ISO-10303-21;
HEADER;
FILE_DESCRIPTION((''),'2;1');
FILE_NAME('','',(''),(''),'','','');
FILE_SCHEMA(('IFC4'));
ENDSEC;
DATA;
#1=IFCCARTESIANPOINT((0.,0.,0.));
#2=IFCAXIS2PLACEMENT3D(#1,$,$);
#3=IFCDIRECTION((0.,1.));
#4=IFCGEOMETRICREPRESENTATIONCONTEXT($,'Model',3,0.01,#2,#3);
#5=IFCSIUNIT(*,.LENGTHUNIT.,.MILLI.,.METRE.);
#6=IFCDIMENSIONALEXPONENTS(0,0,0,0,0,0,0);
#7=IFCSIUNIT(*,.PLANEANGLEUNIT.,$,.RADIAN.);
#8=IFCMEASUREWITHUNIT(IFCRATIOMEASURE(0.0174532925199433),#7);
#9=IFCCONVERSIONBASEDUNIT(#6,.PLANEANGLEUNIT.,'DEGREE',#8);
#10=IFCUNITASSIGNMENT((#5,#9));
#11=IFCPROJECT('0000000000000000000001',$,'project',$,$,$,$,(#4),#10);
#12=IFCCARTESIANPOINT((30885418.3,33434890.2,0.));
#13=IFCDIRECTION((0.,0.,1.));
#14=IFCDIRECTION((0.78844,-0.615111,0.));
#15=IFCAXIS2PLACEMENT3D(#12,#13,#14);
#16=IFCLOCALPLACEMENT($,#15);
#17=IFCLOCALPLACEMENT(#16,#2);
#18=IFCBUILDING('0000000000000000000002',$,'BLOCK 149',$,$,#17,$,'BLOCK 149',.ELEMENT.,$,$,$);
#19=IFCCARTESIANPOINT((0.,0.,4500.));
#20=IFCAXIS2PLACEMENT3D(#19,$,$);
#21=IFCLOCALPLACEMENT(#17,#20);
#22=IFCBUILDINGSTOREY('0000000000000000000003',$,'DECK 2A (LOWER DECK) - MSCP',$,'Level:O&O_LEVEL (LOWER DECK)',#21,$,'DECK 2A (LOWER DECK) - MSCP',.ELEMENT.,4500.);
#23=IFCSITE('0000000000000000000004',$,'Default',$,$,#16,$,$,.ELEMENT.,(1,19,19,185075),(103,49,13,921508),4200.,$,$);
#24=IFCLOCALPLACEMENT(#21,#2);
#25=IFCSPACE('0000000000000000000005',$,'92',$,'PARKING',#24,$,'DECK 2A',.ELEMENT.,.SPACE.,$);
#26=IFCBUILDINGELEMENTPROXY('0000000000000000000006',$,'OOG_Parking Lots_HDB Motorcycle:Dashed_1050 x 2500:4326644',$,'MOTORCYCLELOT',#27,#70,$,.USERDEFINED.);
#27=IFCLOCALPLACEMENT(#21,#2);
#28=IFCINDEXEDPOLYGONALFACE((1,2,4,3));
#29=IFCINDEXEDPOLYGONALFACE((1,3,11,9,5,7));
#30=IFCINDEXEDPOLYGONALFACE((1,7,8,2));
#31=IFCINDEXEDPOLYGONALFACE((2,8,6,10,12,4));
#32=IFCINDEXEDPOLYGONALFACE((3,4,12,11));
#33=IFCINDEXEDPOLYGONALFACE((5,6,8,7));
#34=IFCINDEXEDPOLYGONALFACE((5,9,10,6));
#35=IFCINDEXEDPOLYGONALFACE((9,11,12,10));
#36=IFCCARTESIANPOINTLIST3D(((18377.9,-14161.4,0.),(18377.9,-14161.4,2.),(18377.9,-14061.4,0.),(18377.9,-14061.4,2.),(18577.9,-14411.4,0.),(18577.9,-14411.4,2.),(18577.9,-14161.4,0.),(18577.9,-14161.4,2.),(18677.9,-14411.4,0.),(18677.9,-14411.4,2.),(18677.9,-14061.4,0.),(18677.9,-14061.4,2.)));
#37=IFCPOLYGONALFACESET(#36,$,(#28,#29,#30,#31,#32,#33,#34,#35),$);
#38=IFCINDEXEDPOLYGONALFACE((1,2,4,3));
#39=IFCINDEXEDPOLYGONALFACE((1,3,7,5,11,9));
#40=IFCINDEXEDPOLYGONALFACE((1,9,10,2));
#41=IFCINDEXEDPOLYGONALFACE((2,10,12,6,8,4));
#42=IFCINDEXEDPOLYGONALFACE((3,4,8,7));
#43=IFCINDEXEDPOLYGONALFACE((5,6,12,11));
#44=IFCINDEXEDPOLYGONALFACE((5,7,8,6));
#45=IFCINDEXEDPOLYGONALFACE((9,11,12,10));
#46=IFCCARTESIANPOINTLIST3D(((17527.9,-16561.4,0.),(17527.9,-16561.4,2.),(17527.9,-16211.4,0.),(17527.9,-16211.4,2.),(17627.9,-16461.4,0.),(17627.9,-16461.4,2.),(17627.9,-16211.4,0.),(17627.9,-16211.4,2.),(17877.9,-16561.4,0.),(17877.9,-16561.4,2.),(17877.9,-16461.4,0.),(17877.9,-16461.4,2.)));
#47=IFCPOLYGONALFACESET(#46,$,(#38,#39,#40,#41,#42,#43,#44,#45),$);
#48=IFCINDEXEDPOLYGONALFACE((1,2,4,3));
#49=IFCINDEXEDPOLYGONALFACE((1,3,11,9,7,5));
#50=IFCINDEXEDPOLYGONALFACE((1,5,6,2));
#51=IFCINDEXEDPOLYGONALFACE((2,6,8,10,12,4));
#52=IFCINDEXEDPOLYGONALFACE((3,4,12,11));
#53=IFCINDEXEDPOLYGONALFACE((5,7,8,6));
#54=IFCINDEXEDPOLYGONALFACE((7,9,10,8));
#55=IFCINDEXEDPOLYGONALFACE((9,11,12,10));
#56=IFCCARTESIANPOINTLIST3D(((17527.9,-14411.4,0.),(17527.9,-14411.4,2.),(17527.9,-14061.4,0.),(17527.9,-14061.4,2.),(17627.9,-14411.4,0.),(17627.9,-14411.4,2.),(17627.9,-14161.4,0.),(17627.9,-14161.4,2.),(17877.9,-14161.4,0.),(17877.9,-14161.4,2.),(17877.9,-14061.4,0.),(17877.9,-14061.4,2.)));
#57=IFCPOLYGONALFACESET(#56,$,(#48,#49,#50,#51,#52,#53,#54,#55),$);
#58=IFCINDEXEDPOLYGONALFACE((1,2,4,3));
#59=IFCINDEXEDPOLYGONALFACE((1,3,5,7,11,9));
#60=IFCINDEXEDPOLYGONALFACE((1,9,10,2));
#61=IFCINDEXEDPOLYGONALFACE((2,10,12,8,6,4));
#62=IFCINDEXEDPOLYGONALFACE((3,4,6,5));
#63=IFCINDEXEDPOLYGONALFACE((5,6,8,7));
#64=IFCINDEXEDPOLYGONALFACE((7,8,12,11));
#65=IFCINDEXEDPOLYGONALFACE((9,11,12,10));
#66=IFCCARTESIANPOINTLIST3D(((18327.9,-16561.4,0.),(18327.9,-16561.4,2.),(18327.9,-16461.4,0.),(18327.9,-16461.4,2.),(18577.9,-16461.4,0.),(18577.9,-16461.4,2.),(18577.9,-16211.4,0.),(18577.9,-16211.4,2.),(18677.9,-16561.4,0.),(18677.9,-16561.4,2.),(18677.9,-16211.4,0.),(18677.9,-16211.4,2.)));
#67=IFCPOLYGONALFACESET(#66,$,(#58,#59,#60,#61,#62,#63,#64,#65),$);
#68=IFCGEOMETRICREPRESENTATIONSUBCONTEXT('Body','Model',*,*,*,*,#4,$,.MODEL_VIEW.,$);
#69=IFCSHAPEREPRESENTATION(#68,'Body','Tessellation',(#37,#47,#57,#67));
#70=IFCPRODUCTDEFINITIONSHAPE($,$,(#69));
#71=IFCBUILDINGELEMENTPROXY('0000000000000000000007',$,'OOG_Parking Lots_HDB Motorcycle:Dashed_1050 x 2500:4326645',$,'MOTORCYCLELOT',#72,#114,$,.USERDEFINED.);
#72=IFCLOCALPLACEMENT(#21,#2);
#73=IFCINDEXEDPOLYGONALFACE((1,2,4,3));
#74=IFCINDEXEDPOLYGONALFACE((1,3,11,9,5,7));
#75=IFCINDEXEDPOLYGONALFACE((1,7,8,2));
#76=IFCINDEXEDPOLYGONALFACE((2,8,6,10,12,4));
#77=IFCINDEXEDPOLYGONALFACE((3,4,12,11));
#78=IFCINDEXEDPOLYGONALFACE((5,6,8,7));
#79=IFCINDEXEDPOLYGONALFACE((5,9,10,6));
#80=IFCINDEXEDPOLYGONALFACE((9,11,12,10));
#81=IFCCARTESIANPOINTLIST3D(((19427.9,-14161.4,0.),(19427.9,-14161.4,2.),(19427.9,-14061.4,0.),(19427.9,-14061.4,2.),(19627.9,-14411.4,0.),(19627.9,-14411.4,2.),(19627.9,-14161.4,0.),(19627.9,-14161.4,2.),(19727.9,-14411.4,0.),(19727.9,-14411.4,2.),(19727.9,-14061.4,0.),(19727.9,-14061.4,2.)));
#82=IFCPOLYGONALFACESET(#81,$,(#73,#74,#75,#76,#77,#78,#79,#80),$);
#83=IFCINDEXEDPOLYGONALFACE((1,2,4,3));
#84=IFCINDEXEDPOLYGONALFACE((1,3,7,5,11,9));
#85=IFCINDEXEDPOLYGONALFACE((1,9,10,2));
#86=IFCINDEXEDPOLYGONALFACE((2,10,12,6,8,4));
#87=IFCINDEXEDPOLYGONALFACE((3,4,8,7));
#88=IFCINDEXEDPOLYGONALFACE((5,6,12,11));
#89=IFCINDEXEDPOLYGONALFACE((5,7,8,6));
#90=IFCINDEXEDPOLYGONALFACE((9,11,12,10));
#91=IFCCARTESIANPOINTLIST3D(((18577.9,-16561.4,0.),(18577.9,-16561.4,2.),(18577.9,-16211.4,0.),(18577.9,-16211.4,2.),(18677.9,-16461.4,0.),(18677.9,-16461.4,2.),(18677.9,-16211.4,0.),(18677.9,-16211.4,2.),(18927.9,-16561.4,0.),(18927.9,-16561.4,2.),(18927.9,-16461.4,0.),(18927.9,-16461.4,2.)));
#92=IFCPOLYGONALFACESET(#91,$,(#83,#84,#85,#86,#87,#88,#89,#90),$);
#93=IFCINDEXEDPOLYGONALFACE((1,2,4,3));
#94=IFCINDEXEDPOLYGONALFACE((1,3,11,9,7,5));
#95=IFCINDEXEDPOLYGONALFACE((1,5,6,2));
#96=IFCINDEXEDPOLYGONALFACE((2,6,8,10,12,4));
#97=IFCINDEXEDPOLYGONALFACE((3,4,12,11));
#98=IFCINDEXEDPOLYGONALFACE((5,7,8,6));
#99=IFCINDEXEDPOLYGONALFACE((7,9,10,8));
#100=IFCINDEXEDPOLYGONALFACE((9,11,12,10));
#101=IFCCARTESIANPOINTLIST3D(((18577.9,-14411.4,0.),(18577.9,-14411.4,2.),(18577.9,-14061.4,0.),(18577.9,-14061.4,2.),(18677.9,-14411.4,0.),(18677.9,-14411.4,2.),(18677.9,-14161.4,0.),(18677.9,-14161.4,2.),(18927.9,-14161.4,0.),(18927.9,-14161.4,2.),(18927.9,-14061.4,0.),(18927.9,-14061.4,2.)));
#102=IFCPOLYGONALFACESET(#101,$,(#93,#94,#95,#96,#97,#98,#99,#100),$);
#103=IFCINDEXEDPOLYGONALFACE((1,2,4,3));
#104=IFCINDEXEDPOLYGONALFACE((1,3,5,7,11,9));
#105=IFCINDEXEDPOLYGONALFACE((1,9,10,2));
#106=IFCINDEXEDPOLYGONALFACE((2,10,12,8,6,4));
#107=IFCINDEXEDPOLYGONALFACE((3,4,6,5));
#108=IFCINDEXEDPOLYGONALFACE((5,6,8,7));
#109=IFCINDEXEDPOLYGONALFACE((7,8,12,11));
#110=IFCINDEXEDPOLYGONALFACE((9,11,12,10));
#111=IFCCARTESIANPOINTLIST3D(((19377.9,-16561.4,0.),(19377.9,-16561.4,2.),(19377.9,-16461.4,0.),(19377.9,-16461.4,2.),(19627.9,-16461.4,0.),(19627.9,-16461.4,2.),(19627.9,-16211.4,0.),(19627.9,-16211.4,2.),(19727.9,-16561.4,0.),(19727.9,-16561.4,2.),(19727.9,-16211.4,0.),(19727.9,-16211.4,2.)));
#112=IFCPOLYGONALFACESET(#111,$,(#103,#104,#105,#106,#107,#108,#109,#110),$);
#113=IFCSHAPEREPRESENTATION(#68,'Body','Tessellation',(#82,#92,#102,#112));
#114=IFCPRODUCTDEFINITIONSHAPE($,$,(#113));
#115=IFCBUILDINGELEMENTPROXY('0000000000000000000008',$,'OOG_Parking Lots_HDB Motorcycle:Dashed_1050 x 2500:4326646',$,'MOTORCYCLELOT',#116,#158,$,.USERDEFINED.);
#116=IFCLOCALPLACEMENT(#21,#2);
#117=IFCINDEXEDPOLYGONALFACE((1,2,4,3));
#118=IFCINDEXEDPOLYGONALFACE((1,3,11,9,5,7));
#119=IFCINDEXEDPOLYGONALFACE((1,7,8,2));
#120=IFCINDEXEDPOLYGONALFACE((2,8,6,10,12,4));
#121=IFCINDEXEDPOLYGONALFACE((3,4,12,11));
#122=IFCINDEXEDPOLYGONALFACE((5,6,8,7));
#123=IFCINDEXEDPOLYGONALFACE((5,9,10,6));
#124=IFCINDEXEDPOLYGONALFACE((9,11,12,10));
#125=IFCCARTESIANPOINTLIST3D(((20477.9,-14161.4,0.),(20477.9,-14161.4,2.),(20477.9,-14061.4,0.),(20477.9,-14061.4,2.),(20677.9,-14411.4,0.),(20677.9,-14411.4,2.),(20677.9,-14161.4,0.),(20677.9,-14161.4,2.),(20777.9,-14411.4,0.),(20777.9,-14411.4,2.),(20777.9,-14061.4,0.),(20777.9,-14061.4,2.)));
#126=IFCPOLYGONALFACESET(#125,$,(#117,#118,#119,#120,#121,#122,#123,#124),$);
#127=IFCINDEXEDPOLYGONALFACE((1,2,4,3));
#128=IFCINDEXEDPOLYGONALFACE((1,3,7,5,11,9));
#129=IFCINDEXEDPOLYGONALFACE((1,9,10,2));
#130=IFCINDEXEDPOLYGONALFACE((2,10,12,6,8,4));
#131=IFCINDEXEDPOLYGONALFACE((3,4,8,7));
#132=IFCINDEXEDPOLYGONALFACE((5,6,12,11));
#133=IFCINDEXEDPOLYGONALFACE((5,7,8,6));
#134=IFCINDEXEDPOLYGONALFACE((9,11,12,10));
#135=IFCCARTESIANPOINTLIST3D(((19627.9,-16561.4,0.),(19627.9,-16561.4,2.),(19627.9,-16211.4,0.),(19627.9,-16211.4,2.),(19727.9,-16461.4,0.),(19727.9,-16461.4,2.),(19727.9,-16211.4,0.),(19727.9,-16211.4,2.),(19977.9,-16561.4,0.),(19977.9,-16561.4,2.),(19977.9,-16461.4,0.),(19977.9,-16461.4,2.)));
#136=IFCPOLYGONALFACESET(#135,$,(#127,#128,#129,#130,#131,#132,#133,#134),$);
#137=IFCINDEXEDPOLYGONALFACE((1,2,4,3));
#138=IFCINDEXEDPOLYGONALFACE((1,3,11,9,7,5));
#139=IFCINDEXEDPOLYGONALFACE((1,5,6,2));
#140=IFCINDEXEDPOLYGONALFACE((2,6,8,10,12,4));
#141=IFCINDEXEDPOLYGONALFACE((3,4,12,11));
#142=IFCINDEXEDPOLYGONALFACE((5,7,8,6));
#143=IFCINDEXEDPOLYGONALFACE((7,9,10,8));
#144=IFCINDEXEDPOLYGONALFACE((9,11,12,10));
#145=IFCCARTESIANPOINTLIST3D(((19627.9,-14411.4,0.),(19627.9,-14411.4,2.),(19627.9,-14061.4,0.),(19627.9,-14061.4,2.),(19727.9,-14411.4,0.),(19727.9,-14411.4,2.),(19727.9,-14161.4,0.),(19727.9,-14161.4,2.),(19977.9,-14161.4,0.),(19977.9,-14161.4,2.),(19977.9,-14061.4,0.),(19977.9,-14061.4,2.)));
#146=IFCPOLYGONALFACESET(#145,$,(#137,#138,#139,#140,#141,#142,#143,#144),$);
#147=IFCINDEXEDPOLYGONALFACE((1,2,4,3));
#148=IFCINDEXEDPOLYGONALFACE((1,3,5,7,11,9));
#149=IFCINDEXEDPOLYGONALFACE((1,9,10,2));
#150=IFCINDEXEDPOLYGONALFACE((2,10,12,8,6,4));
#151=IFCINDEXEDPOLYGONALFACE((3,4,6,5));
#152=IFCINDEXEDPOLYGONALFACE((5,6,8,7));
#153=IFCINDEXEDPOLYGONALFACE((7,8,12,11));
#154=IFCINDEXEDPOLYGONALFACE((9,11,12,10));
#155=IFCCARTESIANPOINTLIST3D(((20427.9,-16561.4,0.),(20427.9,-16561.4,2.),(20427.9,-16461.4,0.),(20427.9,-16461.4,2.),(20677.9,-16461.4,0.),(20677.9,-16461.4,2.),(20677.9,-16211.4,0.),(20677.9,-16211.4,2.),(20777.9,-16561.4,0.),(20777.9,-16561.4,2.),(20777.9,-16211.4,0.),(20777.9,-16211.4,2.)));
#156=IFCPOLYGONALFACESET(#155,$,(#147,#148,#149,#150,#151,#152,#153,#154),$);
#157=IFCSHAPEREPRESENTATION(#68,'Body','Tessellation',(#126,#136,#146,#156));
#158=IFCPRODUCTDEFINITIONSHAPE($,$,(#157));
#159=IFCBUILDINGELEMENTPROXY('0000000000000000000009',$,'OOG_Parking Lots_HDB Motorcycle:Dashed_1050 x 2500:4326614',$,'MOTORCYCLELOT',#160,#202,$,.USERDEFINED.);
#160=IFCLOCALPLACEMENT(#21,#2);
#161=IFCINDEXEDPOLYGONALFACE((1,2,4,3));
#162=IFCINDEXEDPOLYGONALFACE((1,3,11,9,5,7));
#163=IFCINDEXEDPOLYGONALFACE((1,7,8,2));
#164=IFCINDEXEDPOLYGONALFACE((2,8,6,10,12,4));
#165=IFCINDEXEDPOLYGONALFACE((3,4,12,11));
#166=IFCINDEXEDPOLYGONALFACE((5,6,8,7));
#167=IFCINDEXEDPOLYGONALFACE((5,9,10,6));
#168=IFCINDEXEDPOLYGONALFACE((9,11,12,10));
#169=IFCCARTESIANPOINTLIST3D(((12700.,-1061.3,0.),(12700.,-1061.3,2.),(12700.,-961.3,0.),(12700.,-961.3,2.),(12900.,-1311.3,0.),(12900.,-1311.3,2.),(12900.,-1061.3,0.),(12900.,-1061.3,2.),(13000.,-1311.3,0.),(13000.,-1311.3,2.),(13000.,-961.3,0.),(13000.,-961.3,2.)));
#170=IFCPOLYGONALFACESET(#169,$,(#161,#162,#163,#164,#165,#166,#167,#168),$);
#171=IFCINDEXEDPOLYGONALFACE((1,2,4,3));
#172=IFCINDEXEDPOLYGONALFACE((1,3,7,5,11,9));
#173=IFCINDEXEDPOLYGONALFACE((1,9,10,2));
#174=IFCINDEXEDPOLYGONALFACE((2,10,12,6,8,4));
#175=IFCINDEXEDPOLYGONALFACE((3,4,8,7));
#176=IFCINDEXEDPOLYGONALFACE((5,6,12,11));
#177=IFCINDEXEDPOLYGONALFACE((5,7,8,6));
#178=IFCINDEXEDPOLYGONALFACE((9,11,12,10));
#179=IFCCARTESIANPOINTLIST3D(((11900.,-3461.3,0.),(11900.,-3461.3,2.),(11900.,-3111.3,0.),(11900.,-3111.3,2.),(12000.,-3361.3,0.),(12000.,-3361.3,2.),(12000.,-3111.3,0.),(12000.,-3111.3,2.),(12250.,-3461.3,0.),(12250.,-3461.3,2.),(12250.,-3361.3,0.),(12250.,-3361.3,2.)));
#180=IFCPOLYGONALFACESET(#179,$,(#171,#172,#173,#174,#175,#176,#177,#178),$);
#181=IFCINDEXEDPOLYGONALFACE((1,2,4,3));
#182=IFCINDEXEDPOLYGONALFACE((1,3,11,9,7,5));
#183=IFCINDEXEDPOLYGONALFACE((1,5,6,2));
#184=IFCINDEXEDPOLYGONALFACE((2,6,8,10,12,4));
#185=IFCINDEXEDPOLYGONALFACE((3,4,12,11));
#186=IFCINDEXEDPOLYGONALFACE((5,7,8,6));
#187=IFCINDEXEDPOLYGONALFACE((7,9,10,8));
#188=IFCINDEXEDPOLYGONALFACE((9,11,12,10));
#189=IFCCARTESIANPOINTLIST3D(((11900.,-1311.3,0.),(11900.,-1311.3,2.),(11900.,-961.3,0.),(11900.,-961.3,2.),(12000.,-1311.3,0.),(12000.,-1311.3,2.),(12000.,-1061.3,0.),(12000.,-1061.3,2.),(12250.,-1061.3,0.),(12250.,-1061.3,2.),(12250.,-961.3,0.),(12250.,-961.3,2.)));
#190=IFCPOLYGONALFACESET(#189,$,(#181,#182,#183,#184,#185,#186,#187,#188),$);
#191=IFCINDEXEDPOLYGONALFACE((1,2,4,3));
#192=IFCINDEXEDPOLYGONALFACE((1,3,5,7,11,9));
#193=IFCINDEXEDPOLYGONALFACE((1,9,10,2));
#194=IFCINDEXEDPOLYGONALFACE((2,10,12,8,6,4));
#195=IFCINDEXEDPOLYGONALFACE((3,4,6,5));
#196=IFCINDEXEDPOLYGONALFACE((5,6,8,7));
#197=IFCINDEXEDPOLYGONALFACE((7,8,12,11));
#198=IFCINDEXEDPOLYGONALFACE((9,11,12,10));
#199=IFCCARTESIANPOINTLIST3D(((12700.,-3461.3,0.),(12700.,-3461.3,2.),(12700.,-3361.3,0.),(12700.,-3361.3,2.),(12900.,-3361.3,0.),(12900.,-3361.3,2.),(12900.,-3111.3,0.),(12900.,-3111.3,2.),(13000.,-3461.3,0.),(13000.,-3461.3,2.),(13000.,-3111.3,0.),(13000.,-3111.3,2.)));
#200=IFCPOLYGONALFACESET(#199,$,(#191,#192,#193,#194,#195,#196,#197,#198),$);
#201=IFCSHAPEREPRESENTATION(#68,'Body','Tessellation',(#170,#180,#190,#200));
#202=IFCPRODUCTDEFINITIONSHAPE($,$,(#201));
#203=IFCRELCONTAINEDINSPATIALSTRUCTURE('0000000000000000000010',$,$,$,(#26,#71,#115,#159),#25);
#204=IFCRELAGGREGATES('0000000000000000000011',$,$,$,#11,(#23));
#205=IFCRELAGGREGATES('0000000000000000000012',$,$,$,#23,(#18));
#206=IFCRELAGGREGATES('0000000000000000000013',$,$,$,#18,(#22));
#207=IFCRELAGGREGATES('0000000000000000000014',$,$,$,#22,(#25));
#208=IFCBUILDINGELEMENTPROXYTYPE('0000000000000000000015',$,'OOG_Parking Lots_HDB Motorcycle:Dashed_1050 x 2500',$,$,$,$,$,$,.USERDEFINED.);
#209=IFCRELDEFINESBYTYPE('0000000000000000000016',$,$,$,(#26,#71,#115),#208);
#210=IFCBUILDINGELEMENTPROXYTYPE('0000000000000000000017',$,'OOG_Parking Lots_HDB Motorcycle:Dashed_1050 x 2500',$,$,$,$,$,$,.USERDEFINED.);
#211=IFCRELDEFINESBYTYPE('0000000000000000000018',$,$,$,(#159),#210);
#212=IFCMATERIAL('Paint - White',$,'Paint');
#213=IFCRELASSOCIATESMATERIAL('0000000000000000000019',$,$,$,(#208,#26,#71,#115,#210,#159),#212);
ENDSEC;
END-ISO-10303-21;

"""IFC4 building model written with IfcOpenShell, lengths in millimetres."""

from ifc_helpers import new_model, entity, si_unit, converted_unit, direction, frame, origin, place, context, subcontext, project, spatial, indexed_curve, outline, extrude, source, transform, mapped, material, type_object, type_shapes, element, save


model = new_model("IFC4")

# Units and contexts
model_context = context("Model", 3, precision=0.01, world=origin(), true_north=direction((0.0, 1.0)))
body_context = subcontext(model_context, "Body", "Model", "MODEL_VIEW")
ifc_project = project(units=[si_unit("LENGTHUNIT", "METRE", prefix="MILLI"), converted_unit("PLANEANGLEUNIT", "DEGREE", entity("IfcRatioMeasure", 0.0174532925199433), si_unit("PLANEANGLEUNIT", "RADIAN"), dimensions=[0, 0, 0, 0, 0, 0, 0])], contexts=[model_context])

# Site, building, storey
site_placement = place(None, frame((30885418.3, 33434890.2, 0.0), z_axis=(0.0, 0.0, 1.0), x_axis=(0.78844, -0.615111, 0.0)))
site = spatial("IfcSite", under=ifc_project, at=site_placement, Name="Default", CompositionType="ELEMENT", RefLatitude=(1, 19, 19, 185075), RefLongitude=(103, 49, 13, 921508), RefElevation=4200.0)
building_placement = place(site_placement, origin())
building = spatial("IfcBuilding", under=site, at=building_placement, Name="BLOCK 149", LongName="BLOCK 149", CompositionType="ELEMENT")
storey_placement = place(building_placement, frame((0.0, 0.0, 4500.0)))
storey = spatial("IfcBuildingStorey", under=building, at=storey_placement, Name="DECK 2A (LOWER DECK) - MSCP", ObjectType="Level:O&O_LEVEL (LOWER DECK)", LongName="DECK 2A (LOWER DECK) - MSCP", CompositionType="ELEMENT", Elevation=4500.0)

# Shared definitions
space_placement = place(storey_placement, origin())
space = spatial("IfcSpace", under=storey, at=space_placement, Name="92", ObjectType="PARKING", LongName="DECK 2A", CompositionType="ELEMENT", PredefinedType="SPACE")

# Building element proxies
ifc_material_1 = material(Name="Paint - White", Category="Paint")
building_element_proxy_type_1 = type_object("IfcBuildingElementProxyType", Name="OOG_Parking Lots_HDB Motorcycle:Dashed_1050 x 2500", PredefinedType="USERDEFINED", material=ifc_material_1)
shared_shape_1 = source(origin(), body_context, "Body", "SweptSolid", [
    extrude(outline(indexed_curve([(-200.0, -133.3), (150.0, -133.3), (150.0, 166.7), (50.0, 166.7), (50.0, -33.3), (-200.0, -33.3), (-200.0, -133.3)], self_intersect=False)), frame((966.7, -100.0, 0.0), z_axis=(0.0, 0.0, 1.0), x_axis=(0.0, 1.0, 0.0)), (0.0, 0.0, 1.0), 2.0),
    extrude(outline(indexed_curve([(-200.0, -150.0), (150.0, -150.0), (150.0, 200.0), (50.0, 200.0), (50.0, -50.0), (-200.0, -50.0), (-200.0, -150.0)], self_intersect=False)), frame((100.0, -2300.0, 0.0), z_axis=(0.0, 0.0, 1.0), x_axis=(0.0, -1.0, 0.0)), (0.0, 0.0, 1.0), 2.0),
    extrude(outline(indexed_curve([(-200.0, -150.0), (150.0, -150.0), (150.0, 200.0), (50.0, 200.0), (50.0, -50.0), (-200.0, -50.0), (-200.0, -150.0)], self_intersect=False)), frame((100.0, -100.0, 0.0), z_axis=(0.0, 0.0, 1.0), x_axis=(-1.0, 0.0, 0.0)), (0.0, 0.0, 1.0), 2.0),
    extrude(outline(indexed_curve([(-200.0, -150.0), (150.0, -150.0), (150.0, 200.0), (50.0, 200.0), (50.0, -50.0), (-200.0, -50.0), (-200.0, -150.0)], self_intersect=False)), frame((950.0, -2300.0, 0.0)), (0.0, 0.0, 1.0), 2.0),
])
type_shapes(building_element_proxy_type_1, [shared_shape_1])
for number, where, name in (
    (1, (17577.9, -14111.4, 0.0), "OOG_Parking Lots_HDB Motorcycle:Dashed_1050 x 2500:4326644"),
    (2, (18627.9, -14111.4, 0.0), "OOG_Parking Lots_HDB Motorcycle:Dashed_1050 x 2500:4326645"),
    (3, (19677.9, -14111.4, 0.0), "OOG_Parking Lots_HDB Motorcycle:Dashed_1050 x 2500:4326646"),
):
    element("IfcBuildingElementProxy", number, at=place(space_placement, frame(where)), inside=space, type_object=building_element_proxy_type_1, material=ifc_material_1, Name=name, ObjectType="MOTORCYCLELOT", PredefinedType="USERDEFINED", context=body_context, shape_type="MappedRepresentation", body=[
        mapped(shared_shape_1, transform((0.0, 0.0, 0.0), scale=1.0)),
    ])
building_element_proxy_type_2 = type_object("IfcBuildingElementProxyType", Name="OOG_Parking Lots_HDB Motorcycle:Dashed_1050 x 2500", PredefinedType="USERDEFINED", material=ifc_material_1)
shared_shape_2 = source(origin(), body_context, "Body", "SweptSolid", [
    extrude(outline(indexed_curve([(-200.0, -133.3), (150.0, -133.3), (150.0, 166.7), (50.0, 166.7), (50.0, -33.3), (-200.0, -33.3), (-200.0, -133.3)], self_intersect=False)), frame((916.7, -100.0, 0.0), z_axis=(0.0, 0.0, 1.0), x_axis=(0.0, 1.0, 0.0)), (0.0, 0.0, 1.0), 2.0),
    extrude(outline(indexed_curve([(-200.0, -150.0), (150.0, -150.0), (150.0, 200.0), (50.0, 200.0), (50.0, -50.0), (-200.0, -50.0), (-200.0, -150.0)], self_intersect=False)), frame((100.0, -2300.0, 0.0), z_axis=(0.0, 0.0, 1.0), x_axis=(0.0, -1.0, 0.0)), (0.0, 0.0, 1.0), 2.0),
    extrude(outline(indexed_curve([(-200.0, -150.0), (150.0, -150.0), (150.0, 200.0), (50.0, 200.0), (50.0, -50.0), (-200.0, -50.0), (-200.0, -150.0)], self_intersect=False)), frame((100.0, -100.0, 0.0), z_axis=(0.0, 0.0, 1.0), x_axis=(-1.0, 0.0, 0.0)), (0.0, 0.0, 1.0), 2.0),
    extrude(outline(indexed_curve([(-166.7, -150.0), (133.3, -150.0), (133.3, 200.0), (33.3, 200.0), (33.3, -50.0), (-166.7, -50.0), (-166.7, -150.0)], self_intersect=False)), frame((916.7, -2300.0, 0.0)), (0.0, 0.0, 1.0), 2.0),
])
type_shapes(building_element_proxy_type_2, [shared_shape_2])
for number, where, name in (
    (4, (11950.0, -1011.3, 0.0), "OOG_Parking Lots_HDB Motorcycle:Dashed_1050 x 2500:4326614"),
):
    element("IfcBuildingElementProxy", number, at=place(space_placement, frame(where)), inside=space, type_object=building_element_proxy_type_2, material=ifc_material_1, Name=name, ObjectType="MOTORCYCLELOT", PredefinedType="USERDEFINED", context=body_context, shape_type="MappedRepresentation", body=[
        mapped(shared_shape_2, transform((0.0, 0.0, 0.0), scale=1.0)),
    ])

save(model, "model.ifc")
